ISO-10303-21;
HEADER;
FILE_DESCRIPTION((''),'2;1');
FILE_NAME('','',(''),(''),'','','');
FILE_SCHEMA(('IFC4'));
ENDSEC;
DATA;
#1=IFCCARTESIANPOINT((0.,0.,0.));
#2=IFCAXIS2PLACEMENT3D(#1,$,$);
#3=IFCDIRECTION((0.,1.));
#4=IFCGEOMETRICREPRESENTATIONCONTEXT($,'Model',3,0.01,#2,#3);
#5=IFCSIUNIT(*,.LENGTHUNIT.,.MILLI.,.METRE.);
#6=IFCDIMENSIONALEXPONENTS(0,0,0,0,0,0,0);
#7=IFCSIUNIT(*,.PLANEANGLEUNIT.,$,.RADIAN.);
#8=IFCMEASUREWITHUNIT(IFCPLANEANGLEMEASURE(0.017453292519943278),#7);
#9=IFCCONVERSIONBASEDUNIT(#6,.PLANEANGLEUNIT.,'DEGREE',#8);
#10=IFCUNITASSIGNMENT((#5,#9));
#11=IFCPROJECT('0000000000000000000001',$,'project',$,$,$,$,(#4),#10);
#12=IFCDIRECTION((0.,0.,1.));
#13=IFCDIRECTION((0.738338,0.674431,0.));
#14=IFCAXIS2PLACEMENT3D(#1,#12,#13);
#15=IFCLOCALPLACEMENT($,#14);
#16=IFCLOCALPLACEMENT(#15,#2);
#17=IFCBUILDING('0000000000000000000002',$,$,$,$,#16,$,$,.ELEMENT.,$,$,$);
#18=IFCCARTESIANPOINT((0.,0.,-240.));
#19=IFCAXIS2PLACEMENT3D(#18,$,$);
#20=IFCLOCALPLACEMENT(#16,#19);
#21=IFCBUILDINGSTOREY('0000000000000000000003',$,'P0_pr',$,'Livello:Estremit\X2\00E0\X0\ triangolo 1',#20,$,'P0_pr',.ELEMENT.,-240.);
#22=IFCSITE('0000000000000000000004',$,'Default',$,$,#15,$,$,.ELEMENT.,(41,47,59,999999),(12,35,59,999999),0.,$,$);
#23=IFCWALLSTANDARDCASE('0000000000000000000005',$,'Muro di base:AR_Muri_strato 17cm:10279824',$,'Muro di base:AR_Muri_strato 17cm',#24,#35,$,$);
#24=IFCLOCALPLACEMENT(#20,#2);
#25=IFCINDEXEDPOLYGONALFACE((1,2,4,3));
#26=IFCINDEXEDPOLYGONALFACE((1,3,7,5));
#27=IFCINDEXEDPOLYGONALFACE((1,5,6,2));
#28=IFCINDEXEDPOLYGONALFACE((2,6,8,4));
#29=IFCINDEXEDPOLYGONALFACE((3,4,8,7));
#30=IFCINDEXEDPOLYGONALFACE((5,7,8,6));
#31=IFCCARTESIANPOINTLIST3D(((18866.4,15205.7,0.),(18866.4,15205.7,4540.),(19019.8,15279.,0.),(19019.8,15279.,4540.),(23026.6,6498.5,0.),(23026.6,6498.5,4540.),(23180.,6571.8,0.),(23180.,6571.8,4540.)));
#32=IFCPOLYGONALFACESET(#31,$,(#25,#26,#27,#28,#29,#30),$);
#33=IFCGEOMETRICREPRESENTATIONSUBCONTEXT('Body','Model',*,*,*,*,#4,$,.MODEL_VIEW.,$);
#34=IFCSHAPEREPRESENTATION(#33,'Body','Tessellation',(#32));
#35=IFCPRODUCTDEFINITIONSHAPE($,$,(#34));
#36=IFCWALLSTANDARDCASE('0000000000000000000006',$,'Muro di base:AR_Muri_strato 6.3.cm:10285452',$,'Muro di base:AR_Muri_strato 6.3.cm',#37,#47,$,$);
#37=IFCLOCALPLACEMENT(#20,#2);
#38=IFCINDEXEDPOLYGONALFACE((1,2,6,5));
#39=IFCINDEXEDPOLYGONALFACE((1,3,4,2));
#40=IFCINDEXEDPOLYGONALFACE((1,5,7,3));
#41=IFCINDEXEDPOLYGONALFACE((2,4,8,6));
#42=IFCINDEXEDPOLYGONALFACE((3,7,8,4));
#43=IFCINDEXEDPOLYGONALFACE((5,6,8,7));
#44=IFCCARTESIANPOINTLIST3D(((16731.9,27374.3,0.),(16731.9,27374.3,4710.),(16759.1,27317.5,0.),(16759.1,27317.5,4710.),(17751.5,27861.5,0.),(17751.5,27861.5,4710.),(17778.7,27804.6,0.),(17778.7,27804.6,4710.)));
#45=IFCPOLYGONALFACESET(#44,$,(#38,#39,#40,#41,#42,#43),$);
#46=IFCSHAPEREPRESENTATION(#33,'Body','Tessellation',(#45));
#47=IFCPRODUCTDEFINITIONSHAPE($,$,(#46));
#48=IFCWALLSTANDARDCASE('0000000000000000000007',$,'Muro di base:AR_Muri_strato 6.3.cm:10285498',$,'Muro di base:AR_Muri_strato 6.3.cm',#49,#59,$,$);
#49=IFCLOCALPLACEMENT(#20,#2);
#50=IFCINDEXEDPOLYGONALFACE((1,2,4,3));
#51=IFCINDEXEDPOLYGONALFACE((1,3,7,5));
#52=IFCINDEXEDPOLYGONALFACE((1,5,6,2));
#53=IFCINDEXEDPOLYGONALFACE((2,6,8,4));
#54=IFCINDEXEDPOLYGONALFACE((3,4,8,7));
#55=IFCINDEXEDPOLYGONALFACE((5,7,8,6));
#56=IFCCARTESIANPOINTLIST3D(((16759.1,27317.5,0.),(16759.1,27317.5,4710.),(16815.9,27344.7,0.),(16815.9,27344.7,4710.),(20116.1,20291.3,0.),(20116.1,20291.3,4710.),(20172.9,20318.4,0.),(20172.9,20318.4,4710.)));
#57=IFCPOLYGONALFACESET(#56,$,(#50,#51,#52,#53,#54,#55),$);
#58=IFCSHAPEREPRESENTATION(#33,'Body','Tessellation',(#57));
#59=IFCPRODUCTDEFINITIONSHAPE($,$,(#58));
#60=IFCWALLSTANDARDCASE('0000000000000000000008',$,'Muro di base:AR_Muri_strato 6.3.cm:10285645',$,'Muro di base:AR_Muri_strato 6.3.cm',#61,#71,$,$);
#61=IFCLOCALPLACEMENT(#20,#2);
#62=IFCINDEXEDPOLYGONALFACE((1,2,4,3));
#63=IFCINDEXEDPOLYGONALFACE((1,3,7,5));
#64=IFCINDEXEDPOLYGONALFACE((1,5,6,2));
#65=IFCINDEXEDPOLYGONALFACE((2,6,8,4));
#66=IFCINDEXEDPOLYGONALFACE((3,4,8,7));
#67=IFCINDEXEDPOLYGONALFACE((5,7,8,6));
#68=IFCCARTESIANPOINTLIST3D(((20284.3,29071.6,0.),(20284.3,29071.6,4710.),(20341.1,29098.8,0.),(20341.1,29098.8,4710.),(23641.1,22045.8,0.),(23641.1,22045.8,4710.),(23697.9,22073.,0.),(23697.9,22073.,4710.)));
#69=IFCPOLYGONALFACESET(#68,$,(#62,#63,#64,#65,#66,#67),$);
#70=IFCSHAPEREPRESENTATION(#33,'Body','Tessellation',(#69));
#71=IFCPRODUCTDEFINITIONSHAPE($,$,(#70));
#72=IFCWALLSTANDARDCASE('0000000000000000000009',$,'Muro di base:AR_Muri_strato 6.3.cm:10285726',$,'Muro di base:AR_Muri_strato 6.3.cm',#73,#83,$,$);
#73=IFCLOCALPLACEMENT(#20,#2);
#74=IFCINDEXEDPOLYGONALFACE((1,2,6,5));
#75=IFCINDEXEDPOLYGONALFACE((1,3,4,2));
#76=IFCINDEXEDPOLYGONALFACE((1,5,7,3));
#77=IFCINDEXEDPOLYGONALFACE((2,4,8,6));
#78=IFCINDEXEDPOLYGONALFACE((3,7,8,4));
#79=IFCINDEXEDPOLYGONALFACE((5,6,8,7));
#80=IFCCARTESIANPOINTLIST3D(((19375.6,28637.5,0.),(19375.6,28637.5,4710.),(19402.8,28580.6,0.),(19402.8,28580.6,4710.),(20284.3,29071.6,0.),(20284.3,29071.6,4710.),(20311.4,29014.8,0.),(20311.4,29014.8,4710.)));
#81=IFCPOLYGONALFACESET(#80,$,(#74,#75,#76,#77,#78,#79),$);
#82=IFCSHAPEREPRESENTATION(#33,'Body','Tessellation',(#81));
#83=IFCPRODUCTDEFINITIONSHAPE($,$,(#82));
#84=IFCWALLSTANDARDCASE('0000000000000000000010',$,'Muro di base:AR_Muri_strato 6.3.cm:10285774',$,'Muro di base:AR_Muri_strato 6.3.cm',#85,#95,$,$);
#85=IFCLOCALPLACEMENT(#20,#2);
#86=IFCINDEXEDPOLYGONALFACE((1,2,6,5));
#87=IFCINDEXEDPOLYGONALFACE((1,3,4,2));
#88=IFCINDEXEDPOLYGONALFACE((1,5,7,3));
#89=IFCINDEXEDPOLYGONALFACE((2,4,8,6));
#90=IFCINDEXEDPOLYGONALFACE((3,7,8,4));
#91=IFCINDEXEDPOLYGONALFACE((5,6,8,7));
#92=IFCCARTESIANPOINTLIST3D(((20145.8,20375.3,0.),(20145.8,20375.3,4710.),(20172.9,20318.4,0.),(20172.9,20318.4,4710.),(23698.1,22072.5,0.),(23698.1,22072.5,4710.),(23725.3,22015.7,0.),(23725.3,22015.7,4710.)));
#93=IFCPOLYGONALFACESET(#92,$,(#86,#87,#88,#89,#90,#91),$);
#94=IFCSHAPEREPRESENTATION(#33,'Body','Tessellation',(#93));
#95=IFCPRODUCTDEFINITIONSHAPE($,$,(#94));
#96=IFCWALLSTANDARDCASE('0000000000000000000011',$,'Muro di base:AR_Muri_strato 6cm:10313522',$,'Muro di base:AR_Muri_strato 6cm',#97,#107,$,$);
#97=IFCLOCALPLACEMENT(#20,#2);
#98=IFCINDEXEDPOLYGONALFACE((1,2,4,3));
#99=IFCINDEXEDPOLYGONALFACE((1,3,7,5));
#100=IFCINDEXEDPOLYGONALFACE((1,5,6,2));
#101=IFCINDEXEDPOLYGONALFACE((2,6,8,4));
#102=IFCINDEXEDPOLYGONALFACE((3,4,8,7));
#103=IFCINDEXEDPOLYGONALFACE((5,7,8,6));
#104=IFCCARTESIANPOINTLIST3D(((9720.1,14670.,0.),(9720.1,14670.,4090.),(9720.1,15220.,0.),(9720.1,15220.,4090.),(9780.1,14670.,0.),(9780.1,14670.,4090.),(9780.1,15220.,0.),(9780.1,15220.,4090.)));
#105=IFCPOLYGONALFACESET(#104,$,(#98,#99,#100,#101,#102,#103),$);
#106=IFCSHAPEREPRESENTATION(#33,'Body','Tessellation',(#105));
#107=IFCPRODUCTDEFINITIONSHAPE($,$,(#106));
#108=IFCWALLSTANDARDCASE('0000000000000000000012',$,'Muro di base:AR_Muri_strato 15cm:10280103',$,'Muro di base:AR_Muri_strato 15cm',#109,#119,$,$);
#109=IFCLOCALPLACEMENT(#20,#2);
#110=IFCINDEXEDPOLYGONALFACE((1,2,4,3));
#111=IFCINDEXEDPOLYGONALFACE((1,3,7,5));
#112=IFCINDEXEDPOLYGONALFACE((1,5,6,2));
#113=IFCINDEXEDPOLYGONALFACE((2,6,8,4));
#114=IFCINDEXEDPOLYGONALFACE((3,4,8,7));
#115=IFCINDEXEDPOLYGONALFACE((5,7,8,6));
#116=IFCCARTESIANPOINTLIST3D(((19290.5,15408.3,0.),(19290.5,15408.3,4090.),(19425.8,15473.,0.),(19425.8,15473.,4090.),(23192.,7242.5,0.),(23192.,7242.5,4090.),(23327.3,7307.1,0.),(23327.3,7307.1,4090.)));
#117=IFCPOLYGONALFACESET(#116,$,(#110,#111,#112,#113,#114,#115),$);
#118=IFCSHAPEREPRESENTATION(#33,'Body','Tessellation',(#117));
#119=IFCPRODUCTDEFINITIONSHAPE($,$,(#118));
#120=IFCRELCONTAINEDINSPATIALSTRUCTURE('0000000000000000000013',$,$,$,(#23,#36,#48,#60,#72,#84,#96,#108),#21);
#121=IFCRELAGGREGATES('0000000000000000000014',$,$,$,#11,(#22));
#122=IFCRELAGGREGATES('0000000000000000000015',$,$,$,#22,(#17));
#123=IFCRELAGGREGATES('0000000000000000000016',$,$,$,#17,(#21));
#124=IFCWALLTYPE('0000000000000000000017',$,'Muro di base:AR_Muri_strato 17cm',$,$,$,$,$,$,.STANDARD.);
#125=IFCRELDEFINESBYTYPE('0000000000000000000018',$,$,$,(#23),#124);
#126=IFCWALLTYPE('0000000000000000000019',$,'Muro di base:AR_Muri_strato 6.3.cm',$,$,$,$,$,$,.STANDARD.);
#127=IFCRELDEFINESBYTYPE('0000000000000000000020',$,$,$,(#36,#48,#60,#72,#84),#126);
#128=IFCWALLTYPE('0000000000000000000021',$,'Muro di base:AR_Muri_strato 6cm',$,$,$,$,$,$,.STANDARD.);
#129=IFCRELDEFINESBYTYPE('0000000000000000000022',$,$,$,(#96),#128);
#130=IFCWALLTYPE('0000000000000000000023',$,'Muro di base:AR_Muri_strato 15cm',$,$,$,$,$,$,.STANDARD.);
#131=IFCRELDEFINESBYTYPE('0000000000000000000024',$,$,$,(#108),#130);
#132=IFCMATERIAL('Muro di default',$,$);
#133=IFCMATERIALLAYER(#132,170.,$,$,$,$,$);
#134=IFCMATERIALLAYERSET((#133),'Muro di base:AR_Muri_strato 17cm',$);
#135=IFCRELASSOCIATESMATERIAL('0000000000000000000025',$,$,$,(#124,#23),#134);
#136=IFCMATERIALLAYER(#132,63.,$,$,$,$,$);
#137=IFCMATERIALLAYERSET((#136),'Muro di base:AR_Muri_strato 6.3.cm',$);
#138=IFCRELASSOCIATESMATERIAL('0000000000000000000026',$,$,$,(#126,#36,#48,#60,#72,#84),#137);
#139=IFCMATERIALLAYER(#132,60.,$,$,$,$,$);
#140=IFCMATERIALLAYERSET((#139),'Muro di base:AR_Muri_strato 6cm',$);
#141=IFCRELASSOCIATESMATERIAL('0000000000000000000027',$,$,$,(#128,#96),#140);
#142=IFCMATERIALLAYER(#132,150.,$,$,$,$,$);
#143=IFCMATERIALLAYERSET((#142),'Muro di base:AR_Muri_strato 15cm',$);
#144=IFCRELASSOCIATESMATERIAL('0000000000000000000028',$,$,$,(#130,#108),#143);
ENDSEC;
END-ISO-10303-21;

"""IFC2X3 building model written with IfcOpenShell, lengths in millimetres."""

from ifc_helpers import new_model, entity, si_unit, converted_unit, direction, frame, frame_2d, origin, place, context, subcontext, project, spatial, rectangle, extrude, material, layer, layer_set, layer_usage, type_object, element, save


model = new_model("IFC2X3")

# Units and contexts
model_context = context("Model", 3, precision=0.01, world=origin(), true_north=direction((0.0, 1.0)))
body_context = subcontext(model_context, "Body", "Model", "MODEL_VIEW")
ifc_project = project(units=[si_unit("LENGTHUNIT", "METRE", prefix="MILLI"), converted_unit("PLANEANGLEUNIT", "DEGREE", entity("IfcPlaneAngleMeasure", 0.017453292519943278), si_unit("PLANEANGLEUNIT", "RADIAN"), dimensions=[0, 0, 0, 0, 0, 0, 0])], contexts=[model_context])

# Site, building, storey
site_placement = place(None, frame((0.0, 0.0, 0.0), z_axis=(0.0, 0.0, 1.0), x_axis=(0.738338, 0.674431, 0.0)))
site = spatial("IfcSite", under=ifc_project, at=site_placement, Name="Default", CompositionType="ELEMENT", RefLatitude=(41, 47, 59, 999999), RefLongitude=(12, 35, 59, 999999), RefElevation=0.0)
building_placement = place(site_placement, origin())
building = spatial("IfcBuilding", under=site, at=building_placement, CompositionType="ELEMENT")
storey_placement = place(building_placement, frame((0.0, 0.0, -240.0)))
storey = spatial("IfcBuildingStorey", under=building, at=storey_placement, Name="P0_pr", ObjectType="Livello:Estremità triangolo 1", LongName="P0_pr", CompositionType="ELEMENT", Elevation=-240.0)

# Shared definitions
ifc_material = material(Name="Muro di default")

# Walls
ifc_layer_1 = layer(ifc_material, 170.0)
ifc_layer_set_1 = layer_set([ifc_layer_1], Name="Muro di base:AR_Muri_strato 17cm")
ifc_layer_usage_1 = layer_usage(ifc_layer_set_1, "AXIS2", "NEGATIVE", 85.0)
wall_type_1 = type_object("IfcWallType", Name="Muro di base:AR_Muri_strato 17cm", PredefinedType="STANDARD", material=ifc_layer_set_1)
wall_1_placement = place(storey_placement, frame((18943.1, 15242.3, 0.0), z_axis=(0.0, 0.0, 1.0), x_axis=(0.431105, -0.902302, 0.0)))
element("IfcWallStandardCase", 1, at=wall_1_placement, inside=storey, type_object=wall_type_1, material=ifc_layer_usage_1, Name="Muro di base:AR_Muri_strato 17cm:10279824", ObjectType="Muro di base:AR_Muri_strato 17cm", context=body_context, shape_type="SweptSolid", body=[
    extrude(rectangle(XDim=9650.0, YDim=170.0, at=frame_2d((4825.0, 0.0), x_axis=(-1.0, 0.0))), origin(), (0.0, 0.0, 1.0), 4540.0),
])
ifc_layer_2 = layer(ifc_material, 63.0)
ifc_layer_set_2 = layer_set([ifc_layer_2], Name="Muro di base:AR_Muri_strato 6.3.cm")
ifc_layer_usage_2 = layer_usage(ifc_layer_set_2, "AXIS2", "NEGATIVE", 31.5)
wall_type_2 = type_object("IfcWallType", Name="Muro di base:AR_Muri_strato 6.3.cm", PredefinedType="STANDARD", material=ifc_layer_set_2)
wall_2_placement = place(storey_placement, frame((17765.1, 27833.1, 0.0), z_axis=(0.0, 0.0, 1.0), x_axis=(-0.902302, -0.431105, 0.0)))
element("IfcWallStandardCase", 2, at=wall_2_placement, inside=storey, type_object=wall_type_2, material=ifc_layer_usage_2, Name="Muro di base:AR_Muri_strato 6.3.cm:10285452", ObjectType="Muro di base:AR_Muri_strato 6.3.cm", context=body_context, shape_type="SweptSolid", body=[
    extrude(rectangle(XDim=1130.0, YDim=63.0, at=frame_2d((565.0, 0.0), x_axis=(-1.0, 0.0))), origin(), (0.0, 0.0, 1.0), 4710.0),
])
ifc_layer_usage_3 = layer_usage(ifc_layer_set_2, "AXIS2", "NEGATIVE", 31.5)
wall_3_placement = place(storey_placement, frame((16787.5, 27331.1, 0.0), z_axis=(0.0, 0.0, 1.0), x_axis=(0.431105, -0.902302, 0.0)))
element("IfcWallStandardCase", 3, at=wall_3_placement, inside=storey, type_object=wall_type_2, material=ifc_layer_usage_3, Name="Muro di base:AR_Muri_strato 6.3.cm:10285498", ObjectType="Muro di base:AR_Muri_strato 6.3.cm", context=body_context, shape_type="SweptSolid", body=[
    extrude(rectangle(XDim=7787.0, YDim=63.0, at=frame_2d((3893.5, 0.0), x_axis=(-1.0, 0.0))), origin(), (0.0, 0.0, 1.0), 4710.0),
])
ifc_layer_usage_4 = layer_usage(ifc_layer_set_2, "AXIS2", "NEGATIVE", 31.5)
wall_4_placement = place(storey_placement, frame((23669.5, 22059.4, 0.0), z_axis=(0.0, 0.0, 1.0), x_axis=(-0.431105, 0.902302, 0.0)))
element("IfcWallStandardCase", 4, at=wall_4_placement, inside=storey, type_object=wall_type_2, material=ifc_layer_usage_4, Name="Muro di base:AR_Muri_strato 6.3.cm:10285645", ObjectType="Muro di base:AR_Muri_strato 6.3.cm", context=body_context, shape_type="SweptSolid", body=[
    extrude(rectangle(XDim=7786.5, YDim=63.0, at=frame_2d((3893.2, 0.0), x_axis=(-1.0, 0.0))), origin(), (0.0, 0.0, 1.0), 4710.0),
])
ifc_layer_usage_5 = layer_usage(ifc_layer_set_2, "AXIS2", "NEGATIVE", 31.5)
wall_5_placement = place(storey_placement, frame((20297.8, 29043.2, 0.0), z_axis=(0.0, 0.0, 1.0), x_axis=(-0.902302, -0.431105, 0.0)))
element("IfcWallStandardCase", 5, at=wall_5_placement, inside=storey, type_object=wall_type_2, material=ifc_layer_usage_5, Name="Muro di base:AR_Muri_strato 6.3.cm:10285726", ObjectType="Muro di base:AR_Muri_strato 6.3.cm", context=body_context, shape_type="SweptSolid", body=[
    extrude(rectangle(XDim=1007.0, YDim=63.0, at=frame_2d((503.5, 0.0), x_axis=(-1.0, 0.0))), origin(), (0.0, 0.0, 1.0), 4710.0),
])
ifc_layer_usage_6 = layer_usage(ifc_layer_set_2, "AXIS2", "NEGATIVE", 31.5)
wall_6_placement = place(storey_placement, frame((20159.3, 20346.9, 0.0), z_axis=(0.0, 0.0, 1.0), x_axis=(0.902302, 0.431105, 0.0)))
element("IfcWallStandardCase", 6, at=wall_6_placement, inside=storey, type_object=wall_type_2, material=ifc_layer_usage_6, Name="Muro di base:AR_Muri_strato 6.3.cm:10285774", ObjectType="Muro di base:AR_Muri_strato 6.3.cm", context=body_context, shape_type="SweptSolid", body=[
    extrude(rectangle(XDim=3937.0, YDim=63.0, at=frame_2d((1968.5, 0.0), x_axis=(-1.0, 0.0))), origin(), (0.0, 0.0, 1.0), 4710.0),
])
ifc_layer_3 = layer(ifc_material, 60.0)
ifc_layer_set_3 = layer_set([ifc_layer_3], Name="Muro di base:AR_Muri_strato 6cm")
ifc_layer_usage_7 = layer_usage(ifc_layer_set_3, "AXIS2", "NEGATIVE", 30.0)
wall_type_3 = type_object("IfcWallType", Name="Muro di base:AR_Muri_strato 6cm", PredefinedType="STANDARD", material=ifc_layer_set_3)
wall_7_placement = place(storey_placement, frame((9750.1, 15220.0, 0.0), z_axis=(0.0, 0.0, 1.0), x_axis=(0.0, -1.0, 0.0)))
element("IfcWallStandardCase", 7, at=wall_7_placement, inside=storey, type_object=wall_type_3, material=ifc_layer_usage_7, Name="Muro di base:AR_Muri_strato 6cm:10313522", ObjectType="Muro di base:AR_Muri_strato 6cm", context=body_context, shape_type="SweptSolid", body=[
    extrude(rectangle(XDim=550.0, YDim=60.0, at=frame_2d((275.0, 0.0), x_axis=(-1.0, 0.0))), origin(), (0.0, 0.0, 1.0), 4090.0),
])
ifc_layer_4 = layer(ifc_material, 150.0)
ifc_layer_set_4 = layer_set([ifc_layer_4], Name="Muro di base:AR_Muri_strato 15cm")
ifc_layer_usage_8 = layer_usage(ifc_layer_set_4, "AXIS2", "NEGATIVE", 75.0)
wall_type_4 = type_object("IfcWallType", Name="Muro di base:AR_Muri_strato 15cm", PredefinedType="STANDARD", material=ifc_layer_set_4)
wall_8_placement = place(storey_placement, frame((23259.7, 7274.8, 0.0), z_axis=(0.0, 0.0, 1.0), x_axis=(-0.431105, 0.902302, 0.0)))
element("IfcWallStandardCase", 8, at=wall_8_placement, inside=storey, type_object=wall_type_4, material=ifc_layer_usage_8, Name="Muro di base:AR_Muri_strato 15cm:10280103", ObjectType="Muro di base:AR_Muri_strato 15cm", context=body_context, shape_type="SweptSolid", body=[
    extrude(rectangle(XDim=9050.0, YDim=150.0, at=frame_2d((4525.0, 0.0), x_axis=(-1.0, 0.0))), origin(), (0.0, 0.0, 1.0), 4090.0),
])

save(model, "model.ifc")
